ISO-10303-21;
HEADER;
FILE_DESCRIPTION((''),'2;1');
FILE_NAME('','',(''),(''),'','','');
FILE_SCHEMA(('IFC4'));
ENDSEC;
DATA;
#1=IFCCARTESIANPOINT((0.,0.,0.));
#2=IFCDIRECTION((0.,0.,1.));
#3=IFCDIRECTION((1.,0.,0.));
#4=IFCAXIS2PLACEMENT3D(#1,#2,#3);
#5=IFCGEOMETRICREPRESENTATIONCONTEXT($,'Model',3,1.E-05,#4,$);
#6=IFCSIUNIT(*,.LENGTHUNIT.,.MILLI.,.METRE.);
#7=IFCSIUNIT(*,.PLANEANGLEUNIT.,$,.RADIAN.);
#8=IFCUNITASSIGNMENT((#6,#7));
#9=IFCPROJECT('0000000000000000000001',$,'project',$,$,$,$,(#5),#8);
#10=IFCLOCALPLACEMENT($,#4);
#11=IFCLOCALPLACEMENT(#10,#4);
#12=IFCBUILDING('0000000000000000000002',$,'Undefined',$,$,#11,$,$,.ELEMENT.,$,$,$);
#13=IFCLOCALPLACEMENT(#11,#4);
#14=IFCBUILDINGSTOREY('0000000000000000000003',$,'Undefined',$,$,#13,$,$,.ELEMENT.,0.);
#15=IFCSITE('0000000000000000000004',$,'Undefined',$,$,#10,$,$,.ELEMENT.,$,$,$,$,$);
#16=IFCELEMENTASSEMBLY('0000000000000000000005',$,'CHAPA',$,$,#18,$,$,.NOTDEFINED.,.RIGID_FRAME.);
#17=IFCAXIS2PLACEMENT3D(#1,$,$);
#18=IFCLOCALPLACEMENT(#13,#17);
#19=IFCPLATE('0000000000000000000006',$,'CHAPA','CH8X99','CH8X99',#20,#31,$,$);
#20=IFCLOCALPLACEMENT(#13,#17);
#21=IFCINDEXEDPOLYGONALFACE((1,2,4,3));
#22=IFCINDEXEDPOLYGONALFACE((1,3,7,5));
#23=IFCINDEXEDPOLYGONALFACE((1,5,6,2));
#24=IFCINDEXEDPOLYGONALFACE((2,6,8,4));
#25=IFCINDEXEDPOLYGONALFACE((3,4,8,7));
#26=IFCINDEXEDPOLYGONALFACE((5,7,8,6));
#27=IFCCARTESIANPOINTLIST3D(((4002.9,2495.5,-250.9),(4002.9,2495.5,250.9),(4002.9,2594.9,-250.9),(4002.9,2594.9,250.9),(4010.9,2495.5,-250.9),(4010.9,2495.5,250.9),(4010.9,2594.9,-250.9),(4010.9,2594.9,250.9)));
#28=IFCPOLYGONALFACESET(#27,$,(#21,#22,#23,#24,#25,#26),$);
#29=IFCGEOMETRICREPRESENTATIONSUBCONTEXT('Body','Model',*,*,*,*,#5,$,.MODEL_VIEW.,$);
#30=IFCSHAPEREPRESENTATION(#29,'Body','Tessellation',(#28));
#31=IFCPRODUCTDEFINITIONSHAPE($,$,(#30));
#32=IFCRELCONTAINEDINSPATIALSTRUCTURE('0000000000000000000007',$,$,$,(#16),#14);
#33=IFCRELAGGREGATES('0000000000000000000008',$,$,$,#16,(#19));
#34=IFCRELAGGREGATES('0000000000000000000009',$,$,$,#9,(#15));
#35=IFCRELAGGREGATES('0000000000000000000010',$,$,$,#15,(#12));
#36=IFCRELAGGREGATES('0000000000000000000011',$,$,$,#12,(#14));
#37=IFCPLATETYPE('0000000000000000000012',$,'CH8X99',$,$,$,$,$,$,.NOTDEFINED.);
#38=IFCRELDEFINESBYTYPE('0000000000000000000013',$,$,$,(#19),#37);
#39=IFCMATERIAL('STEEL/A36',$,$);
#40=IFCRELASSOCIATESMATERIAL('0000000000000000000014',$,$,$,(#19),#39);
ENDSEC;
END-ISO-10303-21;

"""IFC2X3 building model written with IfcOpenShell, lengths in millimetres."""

from ifc_helpers import new_model, si_unit, frame, origin_with_axes, place, context, subcontext, project, spatial, polyline, outline, extrude, material, type_object, element, aggregate, save


model = new_model("IFC2X3")

# Units and contexts
model_context = context("Model", 3, precision=1e-05, world=origin_with_axes())
body_context = subcontext(model_context, "Body", "Model", "MODEL_VIEW")
ifc_project = project(units=[si_unit("LENGTHUNIT", "METRE", prefix="MILLI"), si_unit("PLANEANGLEUNIT", "RADIAN")], contexts=[model_context])

# Site, building, storey
site_placement = place(None, origin_with_axes())
site = spatial("IfcSite", under=ifc_project, at=site_placement, Name="Undefined", CompositionType="ELEMENT")
building_placement = place(site_placement, origin_with_axes())
building = spatial("IfcBuilding", under=site, at=building_placement, Name="Undefined", CompositionType="ELEMENT")
storey_placement = place(building_placement, origin_with_axes())
storey = spatial("IfcBuildingStorey", under=building, at=storey_placement, Name="Undefined", CompositionType="ELEMENT", Elevation=0.0)

# Element assembly, plate
assembly_1_placement = place(storey_placement, origin_with_axes())
assembly_1 = element("IfcElementAssembly", 1, at=assembly_1_placement, inside=storey, Name="CHAPA", AssemblyPlace="NOTDEFINED", PredefinedType="RIGID_FRAME")
ifc_material_1 = material(Name="STEEL/A36")
plate_type = type_object("IfcPlateType", Name="CH8X99", PredefinedType="NOTDEFINED")
plate_placement = place(assembly_1_placement, frame((4006.9, 2495.5, 250.9), z_axis=(-1.0, 0.0, 0.0), x_axis=(0.0, 1.0, 0.0)))
plate = element("IfcPlate", 2, at=plate_placement, type_object=plate_type, material=ifc_material_1, Name="CHAPA", Description="CH8X99", ObjectType="CH8X99", context=body_context, shape_type="SweptSolid", body=[
    extrude(outline(polyline([(0.0, 0.0), (99.4, 0.0), (99.4, 501.8), (0.0, 501.8), (0.0, 0.0)])), frame((0.0, 0.0, -4.0), z_axis=(0.0, 0.0, 1.0), x_axis=(1.0, 0.0, 0.0)), (0.0, 0.0, 1.0), 8.0),
])
aggregate(assembly_1, [plate])

save(model, "model.ifc")
